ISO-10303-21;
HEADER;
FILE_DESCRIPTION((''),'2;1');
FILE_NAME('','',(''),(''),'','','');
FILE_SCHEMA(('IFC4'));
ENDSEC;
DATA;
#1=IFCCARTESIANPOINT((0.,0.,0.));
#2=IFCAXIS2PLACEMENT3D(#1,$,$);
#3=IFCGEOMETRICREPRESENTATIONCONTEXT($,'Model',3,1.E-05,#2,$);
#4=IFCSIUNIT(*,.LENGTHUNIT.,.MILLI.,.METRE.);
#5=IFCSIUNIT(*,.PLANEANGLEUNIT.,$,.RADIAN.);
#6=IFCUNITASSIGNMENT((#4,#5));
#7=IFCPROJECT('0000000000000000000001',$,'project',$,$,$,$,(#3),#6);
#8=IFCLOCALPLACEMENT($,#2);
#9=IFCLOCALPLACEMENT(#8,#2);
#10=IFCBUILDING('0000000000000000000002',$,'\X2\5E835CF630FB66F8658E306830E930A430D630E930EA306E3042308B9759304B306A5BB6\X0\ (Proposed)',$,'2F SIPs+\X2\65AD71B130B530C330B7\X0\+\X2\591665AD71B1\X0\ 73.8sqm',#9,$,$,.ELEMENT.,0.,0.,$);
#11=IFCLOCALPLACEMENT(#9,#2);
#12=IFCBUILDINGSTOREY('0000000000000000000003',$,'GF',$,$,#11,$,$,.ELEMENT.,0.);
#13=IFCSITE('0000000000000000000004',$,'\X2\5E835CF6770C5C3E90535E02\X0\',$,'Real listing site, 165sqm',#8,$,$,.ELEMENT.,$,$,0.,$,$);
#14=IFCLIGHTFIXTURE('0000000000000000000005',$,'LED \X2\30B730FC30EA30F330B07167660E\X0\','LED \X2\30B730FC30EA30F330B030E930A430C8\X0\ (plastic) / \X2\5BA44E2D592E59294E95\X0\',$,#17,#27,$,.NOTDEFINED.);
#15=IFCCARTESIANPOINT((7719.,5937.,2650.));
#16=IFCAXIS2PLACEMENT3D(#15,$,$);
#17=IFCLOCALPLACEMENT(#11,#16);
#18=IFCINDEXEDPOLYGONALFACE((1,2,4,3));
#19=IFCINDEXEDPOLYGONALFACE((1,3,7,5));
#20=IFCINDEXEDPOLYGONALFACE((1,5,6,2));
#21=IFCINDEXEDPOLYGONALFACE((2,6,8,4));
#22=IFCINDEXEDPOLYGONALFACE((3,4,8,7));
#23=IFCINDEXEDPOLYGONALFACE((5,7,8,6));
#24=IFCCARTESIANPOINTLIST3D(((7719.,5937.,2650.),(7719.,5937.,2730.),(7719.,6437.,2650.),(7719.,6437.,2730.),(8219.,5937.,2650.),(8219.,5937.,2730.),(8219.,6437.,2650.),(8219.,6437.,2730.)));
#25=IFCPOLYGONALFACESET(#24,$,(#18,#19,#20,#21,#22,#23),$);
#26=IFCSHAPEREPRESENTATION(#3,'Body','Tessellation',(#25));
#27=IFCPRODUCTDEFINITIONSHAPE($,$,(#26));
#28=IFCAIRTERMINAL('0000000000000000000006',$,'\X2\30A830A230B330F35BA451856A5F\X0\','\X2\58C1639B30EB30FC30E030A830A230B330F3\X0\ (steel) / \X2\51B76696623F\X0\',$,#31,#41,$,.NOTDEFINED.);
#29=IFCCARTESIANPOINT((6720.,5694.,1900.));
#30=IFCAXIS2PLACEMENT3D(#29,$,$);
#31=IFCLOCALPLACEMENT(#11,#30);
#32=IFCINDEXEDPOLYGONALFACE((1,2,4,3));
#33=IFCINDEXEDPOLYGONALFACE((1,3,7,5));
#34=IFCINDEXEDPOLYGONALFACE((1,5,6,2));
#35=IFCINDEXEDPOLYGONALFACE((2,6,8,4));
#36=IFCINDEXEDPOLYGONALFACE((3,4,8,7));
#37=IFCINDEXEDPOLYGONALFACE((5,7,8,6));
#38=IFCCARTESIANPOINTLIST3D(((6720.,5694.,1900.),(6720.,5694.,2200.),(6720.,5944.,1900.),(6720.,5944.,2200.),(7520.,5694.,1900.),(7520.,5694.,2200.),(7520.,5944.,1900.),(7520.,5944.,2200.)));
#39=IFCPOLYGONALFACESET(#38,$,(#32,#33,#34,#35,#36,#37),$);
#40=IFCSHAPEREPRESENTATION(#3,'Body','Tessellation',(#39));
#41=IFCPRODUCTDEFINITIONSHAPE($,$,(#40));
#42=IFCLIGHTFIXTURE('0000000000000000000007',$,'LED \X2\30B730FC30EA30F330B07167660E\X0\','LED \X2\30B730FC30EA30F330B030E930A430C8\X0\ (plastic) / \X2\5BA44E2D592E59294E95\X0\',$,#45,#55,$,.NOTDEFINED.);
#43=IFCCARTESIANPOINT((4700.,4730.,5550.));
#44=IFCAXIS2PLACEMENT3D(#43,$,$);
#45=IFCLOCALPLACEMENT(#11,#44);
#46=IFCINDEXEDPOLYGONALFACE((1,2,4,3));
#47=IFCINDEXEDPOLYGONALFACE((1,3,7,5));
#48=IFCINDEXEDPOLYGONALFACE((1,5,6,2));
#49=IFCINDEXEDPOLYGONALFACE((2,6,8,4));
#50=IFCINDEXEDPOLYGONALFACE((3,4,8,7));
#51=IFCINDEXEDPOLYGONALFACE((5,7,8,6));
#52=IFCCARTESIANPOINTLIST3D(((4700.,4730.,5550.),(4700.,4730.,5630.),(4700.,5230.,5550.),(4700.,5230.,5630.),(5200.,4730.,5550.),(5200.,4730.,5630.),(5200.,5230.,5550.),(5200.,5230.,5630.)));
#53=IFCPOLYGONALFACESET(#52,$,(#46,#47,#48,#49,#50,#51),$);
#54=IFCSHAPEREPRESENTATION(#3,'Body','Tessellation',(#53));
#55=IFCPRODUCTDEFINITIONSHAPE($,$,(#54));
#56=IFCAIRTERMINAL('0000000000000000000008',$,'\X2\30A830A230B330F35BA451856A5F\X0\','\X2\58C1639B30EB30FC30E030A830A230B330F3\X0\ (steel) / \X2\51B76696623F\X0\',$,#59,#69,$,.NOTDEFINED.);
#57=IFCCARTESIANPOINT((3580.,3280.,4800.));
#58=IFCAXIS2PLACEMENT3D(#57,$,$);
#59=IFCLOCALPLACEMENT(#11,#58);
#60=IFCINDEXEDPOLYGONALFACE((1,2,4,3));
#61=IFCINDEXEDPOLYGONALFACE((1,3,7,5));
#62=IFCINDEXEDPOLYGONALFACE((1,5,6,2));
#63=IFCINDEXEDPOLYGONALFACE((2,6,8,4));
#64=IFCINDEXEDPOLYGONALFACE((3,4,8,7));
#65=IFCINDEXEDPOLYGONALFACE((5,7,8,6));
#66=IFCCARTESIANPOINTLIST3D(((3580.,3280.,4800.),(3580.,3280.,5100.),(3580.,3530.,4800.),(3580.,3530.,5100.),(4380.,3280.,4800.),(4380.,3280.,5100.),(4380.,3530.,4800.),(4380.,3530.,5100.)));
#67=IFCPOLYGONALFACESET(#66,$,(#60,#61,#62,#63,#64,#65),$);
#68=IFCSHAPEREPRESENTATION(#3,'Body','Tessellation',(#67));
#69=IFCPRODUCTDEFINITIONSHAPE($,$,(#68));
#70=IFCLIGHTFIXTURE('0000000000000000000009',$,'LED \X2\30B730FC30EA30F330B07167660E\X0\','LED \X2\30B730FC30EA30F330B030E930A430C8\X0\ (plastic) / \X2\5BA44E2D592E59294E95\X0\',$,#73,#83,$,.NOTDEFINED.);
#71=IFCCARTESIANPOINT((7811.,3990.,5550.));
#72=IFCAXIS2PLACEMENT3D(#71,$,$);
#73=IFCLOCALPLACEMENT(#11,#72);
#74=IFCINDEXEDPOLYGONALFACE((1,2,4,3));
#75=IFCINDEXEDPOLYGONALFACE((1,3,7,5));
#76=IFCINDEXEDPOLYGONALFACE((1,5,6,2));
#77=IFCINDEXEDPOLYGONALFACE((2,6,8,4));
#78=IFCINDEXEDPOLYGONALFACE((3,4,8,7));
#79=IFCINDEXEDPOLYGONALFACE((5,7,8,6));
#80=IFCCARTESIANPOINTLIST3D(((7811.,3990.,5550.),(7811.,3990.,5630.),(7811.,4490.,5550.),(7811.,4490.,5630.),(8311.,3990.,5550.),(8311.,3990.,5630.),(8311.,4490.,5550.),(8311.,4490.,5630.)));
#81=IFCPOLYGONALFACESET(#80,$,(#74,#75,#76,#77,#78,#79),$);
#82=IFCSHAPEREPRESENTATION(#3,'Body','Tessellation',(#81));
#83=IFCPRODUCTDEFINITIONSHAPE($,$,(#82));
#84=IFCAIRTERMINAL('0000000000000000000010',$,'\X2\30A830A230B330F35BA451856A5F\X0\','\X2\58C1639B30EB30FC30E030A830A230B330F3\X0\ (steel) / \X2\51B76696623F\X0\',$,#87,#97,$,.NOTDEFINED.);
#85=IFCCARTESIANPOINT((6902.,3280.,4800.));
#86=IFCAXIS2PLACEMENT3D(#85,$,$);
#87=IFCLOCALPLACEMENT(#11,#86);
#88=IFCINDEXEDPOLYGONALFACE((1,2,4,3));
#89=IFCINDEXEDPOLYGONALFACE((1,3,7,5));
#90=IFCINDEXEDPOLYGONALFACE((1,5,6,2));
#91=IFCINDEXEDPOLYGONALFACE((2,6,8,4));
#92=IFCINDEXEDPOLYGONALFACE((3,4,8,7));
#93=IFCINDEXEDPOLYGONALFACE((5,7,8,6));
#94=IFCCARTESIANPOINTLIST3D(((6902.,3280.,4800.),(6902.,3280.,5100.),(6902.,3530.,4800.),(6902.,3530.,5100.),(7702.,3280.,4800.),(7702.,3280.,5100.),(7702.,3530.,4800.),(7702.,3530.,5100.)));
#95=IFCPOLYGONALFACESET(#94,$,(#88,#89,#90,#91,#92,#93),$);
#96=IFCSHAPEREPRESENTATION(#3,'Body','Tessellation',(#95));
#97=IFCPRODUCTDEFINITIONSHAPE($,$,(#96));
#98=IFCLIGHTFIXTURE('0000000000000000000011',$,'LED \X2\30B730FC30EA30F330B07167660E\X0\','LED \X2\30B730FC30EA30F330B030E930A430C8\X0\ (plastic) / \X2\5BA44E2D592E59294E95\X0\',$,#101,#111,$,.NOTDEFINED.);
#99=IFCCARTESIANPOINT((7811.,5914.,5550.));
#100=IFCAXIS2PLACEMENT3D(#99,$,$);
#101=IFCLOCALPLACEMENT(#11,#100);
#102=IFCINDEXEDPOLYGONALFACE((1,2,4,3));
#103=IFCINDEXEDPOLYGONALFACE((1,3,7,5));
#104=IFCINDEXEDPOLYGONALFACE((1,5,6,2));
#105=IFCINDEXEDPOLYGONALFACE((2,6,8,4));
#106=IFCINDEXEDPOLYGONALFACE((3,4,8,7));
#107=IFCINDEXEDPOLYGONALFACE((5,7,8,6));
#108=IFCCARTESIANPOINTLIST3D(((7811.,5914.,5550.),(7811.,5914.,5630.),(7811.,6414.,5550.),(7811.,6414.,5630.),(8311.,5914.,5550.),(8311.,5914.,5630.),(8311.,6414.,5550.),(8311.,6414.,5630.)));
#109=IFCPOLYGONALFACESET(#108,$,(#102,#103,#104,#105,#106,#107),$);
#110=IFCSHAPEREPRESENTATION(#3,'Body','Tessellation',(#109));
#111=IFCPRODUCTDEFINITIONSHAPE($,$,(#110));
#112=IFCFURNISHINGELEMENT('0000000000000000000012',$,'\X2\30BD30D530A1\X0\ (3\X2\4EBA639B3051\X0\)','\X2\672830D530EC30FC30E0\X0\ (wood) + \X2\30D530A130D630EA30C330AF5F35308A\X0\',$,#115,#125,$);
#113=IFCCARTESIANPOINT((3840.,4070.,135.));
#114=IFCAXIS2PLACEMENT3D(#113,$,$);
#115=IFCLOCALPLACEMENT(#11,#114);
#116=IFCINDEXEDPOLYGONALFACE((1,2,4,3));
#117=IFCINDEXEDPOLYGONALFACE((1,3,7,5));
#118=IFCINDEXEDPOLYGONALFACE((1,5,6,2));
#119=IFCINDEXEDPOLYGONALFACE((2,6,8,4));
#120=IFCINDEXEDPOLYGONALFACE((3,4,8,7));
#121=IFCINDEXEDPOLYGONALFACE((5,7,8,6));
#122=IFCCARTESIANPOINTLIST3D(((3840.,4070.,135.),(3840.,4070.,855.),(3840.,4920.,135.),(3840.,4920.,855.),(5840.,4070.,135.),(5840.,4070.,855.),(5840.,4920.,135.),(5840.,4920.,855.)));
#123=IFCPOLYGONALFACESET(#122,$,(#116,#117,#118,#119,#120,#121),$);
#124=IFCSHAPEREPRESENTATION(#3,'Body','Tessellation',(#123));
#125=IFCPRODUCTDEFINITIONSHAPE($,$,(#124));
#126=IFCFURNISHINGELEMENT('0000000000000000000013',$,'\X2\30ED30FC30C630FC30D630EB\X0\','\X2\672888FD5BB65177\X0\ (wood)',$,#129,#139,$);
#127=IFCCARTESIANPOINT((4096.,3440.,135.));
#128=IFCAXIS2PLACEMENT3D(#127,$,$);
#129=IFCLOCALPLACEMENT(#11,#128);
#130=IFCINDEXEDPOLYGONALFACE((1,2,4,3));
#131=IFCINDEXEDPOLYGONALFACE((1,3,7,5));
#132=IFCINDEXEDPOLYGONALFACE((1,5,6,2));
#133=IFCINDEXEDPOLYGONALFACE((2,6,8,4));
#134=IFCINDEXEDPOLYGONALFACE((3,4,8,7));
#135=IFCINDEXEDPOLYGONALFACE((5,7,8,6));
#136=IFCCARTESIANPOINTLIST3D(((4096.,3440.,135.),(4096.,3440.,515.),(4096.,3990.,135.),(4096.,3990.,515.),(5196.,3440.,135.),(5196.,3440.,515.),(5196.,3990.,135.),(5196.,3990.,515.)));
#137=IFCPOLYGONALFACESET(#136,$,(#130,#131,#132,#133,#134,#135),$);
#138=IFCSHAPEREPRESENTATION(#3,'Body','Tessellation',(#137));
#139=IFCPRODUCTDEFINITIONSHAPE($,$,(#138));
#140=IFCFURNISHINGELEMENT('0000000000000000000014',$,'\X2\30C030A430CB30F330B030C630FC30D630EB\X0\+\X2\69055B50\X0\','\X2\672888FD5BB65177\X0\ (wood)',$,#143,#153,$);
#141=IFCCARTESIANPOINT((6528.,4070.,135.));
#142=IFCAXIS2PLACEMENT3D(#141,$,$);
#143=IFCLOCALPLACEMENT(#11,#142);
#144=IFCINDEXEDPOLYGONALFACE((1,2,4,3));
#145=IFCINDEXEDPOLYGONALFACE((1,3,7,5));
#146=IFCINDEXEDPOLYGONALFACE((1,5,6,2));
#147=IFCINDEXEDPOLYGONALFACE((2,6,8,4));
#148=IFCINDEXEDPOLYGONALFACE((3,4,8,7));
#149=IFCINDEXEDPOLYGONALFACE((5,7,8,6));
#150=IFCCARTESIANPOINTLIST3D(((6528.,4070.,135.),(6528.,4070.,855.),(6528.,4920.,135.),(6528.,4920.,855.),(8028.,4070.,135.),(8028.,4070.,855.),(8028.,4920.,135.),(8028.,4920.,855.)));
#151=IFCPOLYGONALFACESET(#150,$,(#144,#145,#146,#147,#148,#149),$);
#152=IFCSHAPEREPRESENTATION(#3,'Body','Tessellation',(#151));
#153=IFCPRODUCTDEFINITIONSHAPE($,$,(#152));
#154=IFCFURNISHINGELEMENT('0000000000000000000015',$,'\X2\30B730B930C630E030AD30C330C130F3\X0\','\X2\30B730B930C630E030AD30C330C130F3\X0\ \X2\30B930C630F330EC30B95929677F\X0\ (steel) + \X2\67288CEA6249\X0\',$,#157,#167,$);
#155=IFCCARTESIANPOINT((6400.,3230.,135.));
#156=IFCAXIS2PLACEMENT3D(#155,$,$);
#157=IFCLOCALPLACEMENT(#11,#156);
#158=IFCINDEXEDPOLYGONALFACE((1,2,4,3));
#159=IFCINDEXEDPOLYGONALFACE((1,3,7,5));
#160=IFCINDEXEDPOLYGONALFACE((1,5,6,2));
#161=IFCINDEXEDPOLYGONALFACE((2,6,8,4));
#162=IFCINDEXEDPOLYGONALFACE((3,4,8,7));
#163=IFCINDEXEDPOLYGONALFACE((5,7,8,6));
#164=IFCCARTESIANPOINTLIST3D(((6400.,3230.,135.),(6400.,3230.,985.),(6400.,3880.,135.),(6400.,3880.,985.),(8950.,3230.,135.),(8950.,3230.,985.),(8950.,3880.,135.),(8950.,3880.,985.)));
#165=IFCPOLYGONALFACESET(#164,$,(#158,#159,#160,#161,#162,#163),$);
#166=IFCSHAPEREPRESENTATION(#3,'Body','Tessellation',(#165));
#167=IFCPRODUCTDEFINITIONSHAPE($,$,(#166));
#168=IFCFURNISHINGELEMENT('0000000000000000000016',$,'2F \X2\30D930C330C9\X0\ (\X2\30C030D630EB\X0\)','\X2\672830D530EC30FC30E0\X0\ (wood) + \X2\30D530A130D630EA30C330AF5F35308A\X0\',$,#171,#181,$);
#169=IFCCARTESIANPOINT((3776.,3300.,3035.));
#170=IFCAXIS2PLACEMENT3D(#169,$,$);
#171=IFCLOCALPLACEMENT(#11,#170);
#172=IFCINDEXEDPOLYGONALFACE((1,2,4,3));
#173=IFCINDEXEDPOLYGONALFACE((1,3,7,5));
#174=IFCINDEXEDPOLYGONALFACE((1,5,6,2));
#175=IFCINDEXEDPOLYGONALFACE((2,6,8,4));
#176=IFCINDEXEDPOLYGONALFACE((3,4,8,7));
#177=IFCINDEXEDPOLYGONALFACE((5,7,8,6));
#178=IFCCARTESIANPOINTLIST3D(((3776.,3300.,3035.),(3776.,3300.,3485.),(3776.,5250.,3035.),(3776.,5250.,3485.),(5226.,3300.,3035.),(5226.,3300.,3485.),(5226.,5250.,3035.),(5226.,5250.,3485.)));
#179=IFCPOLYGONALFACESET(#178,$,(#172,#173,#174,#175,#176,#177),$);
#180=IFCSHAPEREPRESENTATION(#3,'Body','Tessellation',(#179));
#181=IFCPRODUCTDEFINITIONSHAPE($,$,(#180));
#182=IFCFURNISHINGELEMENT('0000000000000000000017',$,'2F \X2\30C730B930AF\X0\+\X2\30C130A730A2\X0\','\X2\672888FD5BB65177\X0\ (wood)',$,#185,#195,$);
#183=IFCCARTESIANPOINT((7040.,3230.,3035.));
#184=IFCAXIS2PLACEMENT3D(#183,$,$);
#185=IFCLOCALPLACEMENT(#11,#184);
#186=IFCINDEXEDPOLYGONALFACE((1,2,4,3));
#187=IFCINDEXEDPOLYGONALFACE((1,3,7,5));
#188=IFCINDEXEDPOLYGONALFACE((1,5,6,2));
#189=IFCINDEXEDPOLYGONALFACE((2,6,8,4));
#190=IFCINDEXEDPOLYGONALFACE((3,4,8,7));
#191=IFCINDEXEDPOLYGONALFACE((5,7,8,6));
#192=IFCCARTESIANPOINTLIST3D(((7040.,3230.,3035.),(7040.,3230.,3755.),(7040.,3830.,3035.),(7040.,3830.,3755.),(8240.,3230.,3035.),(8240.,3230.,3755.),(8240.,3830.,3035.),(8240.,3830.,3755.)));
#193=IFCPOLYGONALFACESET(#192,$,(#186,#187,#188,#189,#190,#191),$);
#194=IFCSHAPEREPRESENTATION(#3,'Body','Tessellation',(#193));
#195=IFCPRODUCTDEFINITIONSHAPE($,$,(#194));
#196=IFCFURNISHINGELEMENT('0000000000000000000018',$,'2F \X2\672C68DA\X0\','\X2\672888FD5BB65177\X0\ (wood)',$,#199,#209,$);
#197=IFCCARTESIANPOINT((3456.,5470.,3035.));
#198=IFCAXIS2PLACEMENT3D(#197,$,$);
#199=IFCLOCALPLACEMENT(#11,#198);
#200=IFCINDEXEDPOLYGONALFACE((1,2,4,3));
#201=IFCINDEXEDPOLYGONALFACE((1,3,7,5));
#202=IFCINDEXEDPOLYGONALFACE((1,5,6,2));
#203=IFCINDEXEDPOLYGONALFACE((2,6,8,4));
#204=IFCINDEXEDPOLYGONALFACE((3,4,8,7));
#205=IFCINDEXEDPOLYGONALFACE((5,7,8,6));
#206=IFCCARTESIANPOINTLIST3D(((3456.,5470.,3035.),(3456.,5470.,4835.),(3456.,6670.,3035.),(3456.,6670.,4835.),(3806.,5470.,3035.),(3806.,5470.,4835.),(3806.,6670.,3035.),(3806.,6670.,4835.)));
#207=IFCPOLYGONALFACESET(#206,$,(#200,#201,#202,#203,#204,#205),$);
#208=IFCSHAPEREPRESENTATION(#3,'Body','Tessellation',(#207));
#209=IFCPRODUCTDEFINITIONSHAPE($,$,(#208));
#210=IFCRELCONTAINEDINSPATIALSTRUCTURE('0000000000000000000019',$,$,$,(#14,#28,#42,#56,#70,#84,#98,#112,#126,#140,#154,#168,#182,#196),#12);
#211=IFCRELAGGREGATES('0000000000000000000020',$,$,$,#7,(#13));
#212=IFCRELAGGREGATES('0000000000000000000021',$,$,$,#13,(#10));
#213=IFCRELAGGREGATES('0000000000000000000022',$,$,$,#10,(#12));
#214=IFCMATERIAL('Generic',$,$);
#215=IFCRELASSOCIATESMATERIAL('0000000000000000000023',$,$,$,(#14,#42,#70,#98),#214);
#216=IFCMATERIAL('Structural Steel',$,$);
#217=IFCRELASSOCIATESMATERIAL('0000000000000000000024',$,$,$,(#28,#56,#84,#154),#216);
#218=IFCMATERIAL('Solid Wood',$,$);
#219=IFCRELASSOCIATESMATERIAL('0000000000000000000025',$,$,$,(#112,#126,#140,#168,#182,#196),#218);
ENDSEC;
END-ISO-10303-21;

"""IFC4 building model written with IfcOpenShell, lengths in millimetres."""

from ifc_helpers import new_model, si_unit, frame, frame_2d, origin, place, context, project, spatial, rectangle, extrude, material, element, save


model = new_model("IFC4")

# Units and contexts
model_context = context("Model", 3, precision=1e-05, world=origin())
ifc_project = project(units=[si_unit("LENGTHUNIT", "METRE", prefix="MILLI"), si_unit("PLANEANGLEUNIT", "RADIAN")], contexts=[model_context])

# Site, building, storey
site_placement = place(None, origin())
site = spatial("IfcSite", under=ifc_project, at=site_placement, Name="広島県尾道市", ObjectType="Real listing site, 165sqm", CompositionType="ELEMENT", RefElevation=0.0)
building_placement = place(site_placement, origin())
building = spatial("IfcBuilding", under=site, at=building_placement, Name="広島・書斎とライブラリのある静かな家 (Proposed)", ObjectType="2F SIPs+断熱サッシ+外断熱 73.8sqm", CompositionType="ELEMENT", ElevationOfRefHeight=0.0, ElevationOfTerrain=0.0)
storey_placement = place(building_placement, origin())
storey = spatial("IfcBuildingStorey", under=building, at=storey_placement, Name="GF", CompositionType="ELEMENT", Elevation=0.0)

# Shared definitions
ifc_material_1 = material(Name="Solid Wood")

# Shared definitions
ifc_material_2 = material(Name="Structural Steel")

# Shared definitions
ifc_material_3 = material(Name="Generic")

# Light fixture
light_fixture_1_placement = place(storey_placement, frame((7719.0, 5937.0, 2650.0)))
element("IfcLightFixture", 1, at=light_fixture_1_placement, inside=storey, material=ifc_material_3, Name="LED シーリング照明", Description="LED シーリングライト (plastic) / 室中央天井", PredefinedType="NOTDEFINED", context=model_context, shape_type="SweptSolid", body=[
    extrude(rectangle(XDim=500.0, YDim=500.0, at=frame_2d((250.0, 250.0))), frame((7719.0, 5937.0, 2650.0)), (0.0, 0.0, 1.0), 80.0),
])

# Air terminal
air_terminal_1_placement = place(storey_placement, frame((6720.0, 5694.0, 1900.0)))
element("IfcAirTerminal", 2, at=air_terminal_1_placement, inside=storey, material=ifc_material_2, Name="エアコン室内機", Description="壁掛ルームエアコン (steel) / 冷暖房", PredefinedType="NOTDEFINED", context=model_context, shape_type="SweptSolid", body=[
    extrude(rectangle(XDim=800.0, YDim=250.0, at=frame_2d((400.0, 125.0))), frame((6720.0, 5694.0, 1900.0)), (0.0, 0.0, 1.0), 300.0),
])

# Light fixture
light_fixture_2_placement = place(storey_placement, frame((4700.0, 4730.0, 5550.0)))
element("IfcLightFixture", 3, at=light_fixture_2_placement, inside=storey, material=ifc_material_3, Name="LED シーリング照明", Description="LED シーリングライト (plastic) / 室中央天井", PredefinedType="NOTDEFINED", context=model_context, shape_type="SweptSolid", body=[
    extrude(rectangle(XDim=500.0, YDim=500.0, at=frame_2d((250.0, 250.0))), frame((4700.0, 4730.0, 5550.0)), (0.0, 0.0, 1.0), 80.0),
])

# Air terminal
air_terminal_2_placement = place(storey_placement, frame((3580.0, 3280.0, 4800.0)))
element("IfcAirTerminal", 4, at=air_terminal_2_placement, inside=storey, material=ifc_material_2, Name="エアコン室内機", Description="壁掛ルームエアコン (steel) / 冷暖房", PredefinedType="NOTDEFINED", context=model_context, shape_type="SweptSolid", body=[
    extrude(rectangle(XDim=800.0, YDim=250.0, at=frame_2d((400.0, 125.0))), frame((3580.0, 3280.0, 4800.0)), (0.0, 0.0, 1.0), 300.0),
])

# Light fixture
light_fixture_3_placement = place(storey_placement, frame((7811.0, 3990.0, 5550.0)))
element("IfcLightFixture", 5, at=light_fixture_3_placement, inside=storey, material=ifc_material_3, Name="LED シーリング照明", Description="LED シーリングライト (plastic) / 室中央天井", PredefinedType="NOTDEFINED", context=model_context, shape_type="SweptSolid", body=[
    extrude(rectangle(XDim=500.0, YDim=500.0, at=frame_2d((250.0, 250.0))), frame((7811.0, 3990.0, 5550.0)), (0.0, 0.0, 1.0), 80.0),
])

# Air terminal
air_terminal_3_placement = place(storey_placement, frame((6902.0, 3280.0, 4800.0)))
element("IfcAirTerminal", 6, at=air_terminal_3_placement, inside=storey, material=ifc_material_2, Name="エアコン室内機", Description="壁掛ルームエアコン (steel) / 冷暖房", PredefinedType="NOTDEFINED", context=model_context, shape_type="SweptSolid", body=[
    extrude(rectangle(XDim=800.0, YDim=250.0, at=frame_2d((400.0, 125.0))), frame((6902.0, 3280.0, 4800.0)), (0.0, 0.0, 1.0), 300.0),
])

# Light fixture
light_fixture_4_placement = place(storey_placement, frame((7811.0, 5914.0, 5550.0)))
element("IfcLightFixture", 7, at=light_fixture_4_placement, inside=storey, material=ifc_material_3, Name="LED シーリング照明", Description="LED シーリングライト (plastic) / 室中央天井", PredefinedType="NOTDEFINED", context=model_context, shape_type="SweptSolid", body=[
    extrude(rectangle(XDim=500.0, YDim=500.0, at=frame_2d((250.0, 250.0))), frame((7811.0, 5914.0, 5550.0)), (0.0, 0.0, 1.0), 80.0),
])

# Furnishing elements
furnishing_1_placement = place(storey_placement, frame((3840.0, 4070.0, 135.0)))
element("IfcFurnishingElement", 8, at=furnishing_1_placement, inside=storey, material=ifc_material_1, Name="ソファ (3人掛け)", Description="木フレーム (wood) + ファブリック張り", context=model_context, shape_type="SweptSolid", body=[
    extrude(rectangle(XDim=2000.0, YDim=850.0, at=frame_2d((1000.0, 425.0))), frame((3840.0, 4070.0, 135.0)), (0.0, 0.0, 1.0), 720.0),
])
furnishing_2_placement = place(storey_placement, frame((4096.0, 3440.0, 135.0)))
element("IfcFurnishingElement", 9, at=furnishing_2_placement, inside=storey, material=ifc_material_1, Name="ローテーブル", Description="木製家具 (wood)", context=model_context, shape_type="SweptSolid", body=[
    extrude(rectangle(XDim=1100.0, YDim=550.0, at=frame_2d((550.0, 275.0))), frame((4096.0, 3440.0, 135.0)), (0.0, 0.0, 1.0), 380.0),
])
furnishing_3_placement = place(storey_placement, frame((6528.0, 4070.0, 135.0)))
element("IfcFurnishingElement", 10, at=furnishing_3_placement, inside=storey, material=ifc_material_1, Name="ダイニングテーブル+椅子", Description="木製家具 (wood)", context=model_context, shape_type="SweptSolid", body=[
    extrude(rectangle(XDim=1500.0, YDim=850.0, at=frame_2d((750.0, 425.0))), frame((6528.0, 4070.0, 135.0)), (0.0, 0.0, 1.0), 720.0),
])
furnishing_4_placement = place(storey_placement, frame((6400.0, 3230.0, 135.0)))
element("IfcFurnishingElement", 11, at=furnishing_4_placement, inside=storey, material=ifc_material_2, Name="システムキッチン", Description="システムキッチン ステンレス天板 (steel) + 木質扉", context=model_context, shape_type="SweptSolid", body=[
    extrude(rectangle(XDim=2550.0, YDim=650.0, at=frame_2d((1275.0, 325.0))), frame((6400.0, 3230.0, 135.0)), (0.0, 0.0, 1.0), 850.0),
])
furnishing_5_placement = place(storey_placement, frame((3776.0, 3300.0, 3035.0)))
element("IfcFurnishingElement", 12, at=furnishing_5_placement, inside=storey, material=ifc_material_1, Name="2F ベッド (ダブル)", Description="木フレーム (wood) + ファブリック張り", context=model_context, shape_type="SweptSolid", body=[
    extrude(rectangle(XDim=1450.0, YDim=1950.0, at=frame_2d((725.0, 975.0))), frame((3776.0, 3300.0, 3035.0)), (0.0, 0.0, 1.0), 450.0),
])
furnishing_6_placement = place(storey_placement, frame((7040.0, 3230.0, 3035.0)))
element("IfcFurnishingElement", 13, at=furnishing_6_placement, inside=storey, material=ifc_material_1, Name="2F デスク+チェア", Description="木製家具 (wood)", context=model_context, shape_type="SweptSolid", body=[
    extrude(rectangle(XDim=1200.0, YDim=600.0, at=frame_2d((600.0, 300.0))), frame((7040.0, 3230.0, 3035.0)), (0.0, 0.0, 1.0), 720.0),
])
furnishing_7_placement = place(storey_placement, frame((3456.0, 5470.0, 3035.0)))
element("IfcFurnishingElement", 14, at=furnishing_7_placement, inside=storey, material=ifc_material_1, Name="2F 本棚", Description="木製家具 (wood)", context=model_context, shape_type="SweptSolid", body=[
    extrude(rectangle(XDim=350.0, YDim=1200.0, at=frame_2d((175.0, 600.0))), frame((3456.0, 5470.0, 3035.0)), (0.0, 0.0, 1.0), 1800.0),
])

save(model, "model.ifc")
